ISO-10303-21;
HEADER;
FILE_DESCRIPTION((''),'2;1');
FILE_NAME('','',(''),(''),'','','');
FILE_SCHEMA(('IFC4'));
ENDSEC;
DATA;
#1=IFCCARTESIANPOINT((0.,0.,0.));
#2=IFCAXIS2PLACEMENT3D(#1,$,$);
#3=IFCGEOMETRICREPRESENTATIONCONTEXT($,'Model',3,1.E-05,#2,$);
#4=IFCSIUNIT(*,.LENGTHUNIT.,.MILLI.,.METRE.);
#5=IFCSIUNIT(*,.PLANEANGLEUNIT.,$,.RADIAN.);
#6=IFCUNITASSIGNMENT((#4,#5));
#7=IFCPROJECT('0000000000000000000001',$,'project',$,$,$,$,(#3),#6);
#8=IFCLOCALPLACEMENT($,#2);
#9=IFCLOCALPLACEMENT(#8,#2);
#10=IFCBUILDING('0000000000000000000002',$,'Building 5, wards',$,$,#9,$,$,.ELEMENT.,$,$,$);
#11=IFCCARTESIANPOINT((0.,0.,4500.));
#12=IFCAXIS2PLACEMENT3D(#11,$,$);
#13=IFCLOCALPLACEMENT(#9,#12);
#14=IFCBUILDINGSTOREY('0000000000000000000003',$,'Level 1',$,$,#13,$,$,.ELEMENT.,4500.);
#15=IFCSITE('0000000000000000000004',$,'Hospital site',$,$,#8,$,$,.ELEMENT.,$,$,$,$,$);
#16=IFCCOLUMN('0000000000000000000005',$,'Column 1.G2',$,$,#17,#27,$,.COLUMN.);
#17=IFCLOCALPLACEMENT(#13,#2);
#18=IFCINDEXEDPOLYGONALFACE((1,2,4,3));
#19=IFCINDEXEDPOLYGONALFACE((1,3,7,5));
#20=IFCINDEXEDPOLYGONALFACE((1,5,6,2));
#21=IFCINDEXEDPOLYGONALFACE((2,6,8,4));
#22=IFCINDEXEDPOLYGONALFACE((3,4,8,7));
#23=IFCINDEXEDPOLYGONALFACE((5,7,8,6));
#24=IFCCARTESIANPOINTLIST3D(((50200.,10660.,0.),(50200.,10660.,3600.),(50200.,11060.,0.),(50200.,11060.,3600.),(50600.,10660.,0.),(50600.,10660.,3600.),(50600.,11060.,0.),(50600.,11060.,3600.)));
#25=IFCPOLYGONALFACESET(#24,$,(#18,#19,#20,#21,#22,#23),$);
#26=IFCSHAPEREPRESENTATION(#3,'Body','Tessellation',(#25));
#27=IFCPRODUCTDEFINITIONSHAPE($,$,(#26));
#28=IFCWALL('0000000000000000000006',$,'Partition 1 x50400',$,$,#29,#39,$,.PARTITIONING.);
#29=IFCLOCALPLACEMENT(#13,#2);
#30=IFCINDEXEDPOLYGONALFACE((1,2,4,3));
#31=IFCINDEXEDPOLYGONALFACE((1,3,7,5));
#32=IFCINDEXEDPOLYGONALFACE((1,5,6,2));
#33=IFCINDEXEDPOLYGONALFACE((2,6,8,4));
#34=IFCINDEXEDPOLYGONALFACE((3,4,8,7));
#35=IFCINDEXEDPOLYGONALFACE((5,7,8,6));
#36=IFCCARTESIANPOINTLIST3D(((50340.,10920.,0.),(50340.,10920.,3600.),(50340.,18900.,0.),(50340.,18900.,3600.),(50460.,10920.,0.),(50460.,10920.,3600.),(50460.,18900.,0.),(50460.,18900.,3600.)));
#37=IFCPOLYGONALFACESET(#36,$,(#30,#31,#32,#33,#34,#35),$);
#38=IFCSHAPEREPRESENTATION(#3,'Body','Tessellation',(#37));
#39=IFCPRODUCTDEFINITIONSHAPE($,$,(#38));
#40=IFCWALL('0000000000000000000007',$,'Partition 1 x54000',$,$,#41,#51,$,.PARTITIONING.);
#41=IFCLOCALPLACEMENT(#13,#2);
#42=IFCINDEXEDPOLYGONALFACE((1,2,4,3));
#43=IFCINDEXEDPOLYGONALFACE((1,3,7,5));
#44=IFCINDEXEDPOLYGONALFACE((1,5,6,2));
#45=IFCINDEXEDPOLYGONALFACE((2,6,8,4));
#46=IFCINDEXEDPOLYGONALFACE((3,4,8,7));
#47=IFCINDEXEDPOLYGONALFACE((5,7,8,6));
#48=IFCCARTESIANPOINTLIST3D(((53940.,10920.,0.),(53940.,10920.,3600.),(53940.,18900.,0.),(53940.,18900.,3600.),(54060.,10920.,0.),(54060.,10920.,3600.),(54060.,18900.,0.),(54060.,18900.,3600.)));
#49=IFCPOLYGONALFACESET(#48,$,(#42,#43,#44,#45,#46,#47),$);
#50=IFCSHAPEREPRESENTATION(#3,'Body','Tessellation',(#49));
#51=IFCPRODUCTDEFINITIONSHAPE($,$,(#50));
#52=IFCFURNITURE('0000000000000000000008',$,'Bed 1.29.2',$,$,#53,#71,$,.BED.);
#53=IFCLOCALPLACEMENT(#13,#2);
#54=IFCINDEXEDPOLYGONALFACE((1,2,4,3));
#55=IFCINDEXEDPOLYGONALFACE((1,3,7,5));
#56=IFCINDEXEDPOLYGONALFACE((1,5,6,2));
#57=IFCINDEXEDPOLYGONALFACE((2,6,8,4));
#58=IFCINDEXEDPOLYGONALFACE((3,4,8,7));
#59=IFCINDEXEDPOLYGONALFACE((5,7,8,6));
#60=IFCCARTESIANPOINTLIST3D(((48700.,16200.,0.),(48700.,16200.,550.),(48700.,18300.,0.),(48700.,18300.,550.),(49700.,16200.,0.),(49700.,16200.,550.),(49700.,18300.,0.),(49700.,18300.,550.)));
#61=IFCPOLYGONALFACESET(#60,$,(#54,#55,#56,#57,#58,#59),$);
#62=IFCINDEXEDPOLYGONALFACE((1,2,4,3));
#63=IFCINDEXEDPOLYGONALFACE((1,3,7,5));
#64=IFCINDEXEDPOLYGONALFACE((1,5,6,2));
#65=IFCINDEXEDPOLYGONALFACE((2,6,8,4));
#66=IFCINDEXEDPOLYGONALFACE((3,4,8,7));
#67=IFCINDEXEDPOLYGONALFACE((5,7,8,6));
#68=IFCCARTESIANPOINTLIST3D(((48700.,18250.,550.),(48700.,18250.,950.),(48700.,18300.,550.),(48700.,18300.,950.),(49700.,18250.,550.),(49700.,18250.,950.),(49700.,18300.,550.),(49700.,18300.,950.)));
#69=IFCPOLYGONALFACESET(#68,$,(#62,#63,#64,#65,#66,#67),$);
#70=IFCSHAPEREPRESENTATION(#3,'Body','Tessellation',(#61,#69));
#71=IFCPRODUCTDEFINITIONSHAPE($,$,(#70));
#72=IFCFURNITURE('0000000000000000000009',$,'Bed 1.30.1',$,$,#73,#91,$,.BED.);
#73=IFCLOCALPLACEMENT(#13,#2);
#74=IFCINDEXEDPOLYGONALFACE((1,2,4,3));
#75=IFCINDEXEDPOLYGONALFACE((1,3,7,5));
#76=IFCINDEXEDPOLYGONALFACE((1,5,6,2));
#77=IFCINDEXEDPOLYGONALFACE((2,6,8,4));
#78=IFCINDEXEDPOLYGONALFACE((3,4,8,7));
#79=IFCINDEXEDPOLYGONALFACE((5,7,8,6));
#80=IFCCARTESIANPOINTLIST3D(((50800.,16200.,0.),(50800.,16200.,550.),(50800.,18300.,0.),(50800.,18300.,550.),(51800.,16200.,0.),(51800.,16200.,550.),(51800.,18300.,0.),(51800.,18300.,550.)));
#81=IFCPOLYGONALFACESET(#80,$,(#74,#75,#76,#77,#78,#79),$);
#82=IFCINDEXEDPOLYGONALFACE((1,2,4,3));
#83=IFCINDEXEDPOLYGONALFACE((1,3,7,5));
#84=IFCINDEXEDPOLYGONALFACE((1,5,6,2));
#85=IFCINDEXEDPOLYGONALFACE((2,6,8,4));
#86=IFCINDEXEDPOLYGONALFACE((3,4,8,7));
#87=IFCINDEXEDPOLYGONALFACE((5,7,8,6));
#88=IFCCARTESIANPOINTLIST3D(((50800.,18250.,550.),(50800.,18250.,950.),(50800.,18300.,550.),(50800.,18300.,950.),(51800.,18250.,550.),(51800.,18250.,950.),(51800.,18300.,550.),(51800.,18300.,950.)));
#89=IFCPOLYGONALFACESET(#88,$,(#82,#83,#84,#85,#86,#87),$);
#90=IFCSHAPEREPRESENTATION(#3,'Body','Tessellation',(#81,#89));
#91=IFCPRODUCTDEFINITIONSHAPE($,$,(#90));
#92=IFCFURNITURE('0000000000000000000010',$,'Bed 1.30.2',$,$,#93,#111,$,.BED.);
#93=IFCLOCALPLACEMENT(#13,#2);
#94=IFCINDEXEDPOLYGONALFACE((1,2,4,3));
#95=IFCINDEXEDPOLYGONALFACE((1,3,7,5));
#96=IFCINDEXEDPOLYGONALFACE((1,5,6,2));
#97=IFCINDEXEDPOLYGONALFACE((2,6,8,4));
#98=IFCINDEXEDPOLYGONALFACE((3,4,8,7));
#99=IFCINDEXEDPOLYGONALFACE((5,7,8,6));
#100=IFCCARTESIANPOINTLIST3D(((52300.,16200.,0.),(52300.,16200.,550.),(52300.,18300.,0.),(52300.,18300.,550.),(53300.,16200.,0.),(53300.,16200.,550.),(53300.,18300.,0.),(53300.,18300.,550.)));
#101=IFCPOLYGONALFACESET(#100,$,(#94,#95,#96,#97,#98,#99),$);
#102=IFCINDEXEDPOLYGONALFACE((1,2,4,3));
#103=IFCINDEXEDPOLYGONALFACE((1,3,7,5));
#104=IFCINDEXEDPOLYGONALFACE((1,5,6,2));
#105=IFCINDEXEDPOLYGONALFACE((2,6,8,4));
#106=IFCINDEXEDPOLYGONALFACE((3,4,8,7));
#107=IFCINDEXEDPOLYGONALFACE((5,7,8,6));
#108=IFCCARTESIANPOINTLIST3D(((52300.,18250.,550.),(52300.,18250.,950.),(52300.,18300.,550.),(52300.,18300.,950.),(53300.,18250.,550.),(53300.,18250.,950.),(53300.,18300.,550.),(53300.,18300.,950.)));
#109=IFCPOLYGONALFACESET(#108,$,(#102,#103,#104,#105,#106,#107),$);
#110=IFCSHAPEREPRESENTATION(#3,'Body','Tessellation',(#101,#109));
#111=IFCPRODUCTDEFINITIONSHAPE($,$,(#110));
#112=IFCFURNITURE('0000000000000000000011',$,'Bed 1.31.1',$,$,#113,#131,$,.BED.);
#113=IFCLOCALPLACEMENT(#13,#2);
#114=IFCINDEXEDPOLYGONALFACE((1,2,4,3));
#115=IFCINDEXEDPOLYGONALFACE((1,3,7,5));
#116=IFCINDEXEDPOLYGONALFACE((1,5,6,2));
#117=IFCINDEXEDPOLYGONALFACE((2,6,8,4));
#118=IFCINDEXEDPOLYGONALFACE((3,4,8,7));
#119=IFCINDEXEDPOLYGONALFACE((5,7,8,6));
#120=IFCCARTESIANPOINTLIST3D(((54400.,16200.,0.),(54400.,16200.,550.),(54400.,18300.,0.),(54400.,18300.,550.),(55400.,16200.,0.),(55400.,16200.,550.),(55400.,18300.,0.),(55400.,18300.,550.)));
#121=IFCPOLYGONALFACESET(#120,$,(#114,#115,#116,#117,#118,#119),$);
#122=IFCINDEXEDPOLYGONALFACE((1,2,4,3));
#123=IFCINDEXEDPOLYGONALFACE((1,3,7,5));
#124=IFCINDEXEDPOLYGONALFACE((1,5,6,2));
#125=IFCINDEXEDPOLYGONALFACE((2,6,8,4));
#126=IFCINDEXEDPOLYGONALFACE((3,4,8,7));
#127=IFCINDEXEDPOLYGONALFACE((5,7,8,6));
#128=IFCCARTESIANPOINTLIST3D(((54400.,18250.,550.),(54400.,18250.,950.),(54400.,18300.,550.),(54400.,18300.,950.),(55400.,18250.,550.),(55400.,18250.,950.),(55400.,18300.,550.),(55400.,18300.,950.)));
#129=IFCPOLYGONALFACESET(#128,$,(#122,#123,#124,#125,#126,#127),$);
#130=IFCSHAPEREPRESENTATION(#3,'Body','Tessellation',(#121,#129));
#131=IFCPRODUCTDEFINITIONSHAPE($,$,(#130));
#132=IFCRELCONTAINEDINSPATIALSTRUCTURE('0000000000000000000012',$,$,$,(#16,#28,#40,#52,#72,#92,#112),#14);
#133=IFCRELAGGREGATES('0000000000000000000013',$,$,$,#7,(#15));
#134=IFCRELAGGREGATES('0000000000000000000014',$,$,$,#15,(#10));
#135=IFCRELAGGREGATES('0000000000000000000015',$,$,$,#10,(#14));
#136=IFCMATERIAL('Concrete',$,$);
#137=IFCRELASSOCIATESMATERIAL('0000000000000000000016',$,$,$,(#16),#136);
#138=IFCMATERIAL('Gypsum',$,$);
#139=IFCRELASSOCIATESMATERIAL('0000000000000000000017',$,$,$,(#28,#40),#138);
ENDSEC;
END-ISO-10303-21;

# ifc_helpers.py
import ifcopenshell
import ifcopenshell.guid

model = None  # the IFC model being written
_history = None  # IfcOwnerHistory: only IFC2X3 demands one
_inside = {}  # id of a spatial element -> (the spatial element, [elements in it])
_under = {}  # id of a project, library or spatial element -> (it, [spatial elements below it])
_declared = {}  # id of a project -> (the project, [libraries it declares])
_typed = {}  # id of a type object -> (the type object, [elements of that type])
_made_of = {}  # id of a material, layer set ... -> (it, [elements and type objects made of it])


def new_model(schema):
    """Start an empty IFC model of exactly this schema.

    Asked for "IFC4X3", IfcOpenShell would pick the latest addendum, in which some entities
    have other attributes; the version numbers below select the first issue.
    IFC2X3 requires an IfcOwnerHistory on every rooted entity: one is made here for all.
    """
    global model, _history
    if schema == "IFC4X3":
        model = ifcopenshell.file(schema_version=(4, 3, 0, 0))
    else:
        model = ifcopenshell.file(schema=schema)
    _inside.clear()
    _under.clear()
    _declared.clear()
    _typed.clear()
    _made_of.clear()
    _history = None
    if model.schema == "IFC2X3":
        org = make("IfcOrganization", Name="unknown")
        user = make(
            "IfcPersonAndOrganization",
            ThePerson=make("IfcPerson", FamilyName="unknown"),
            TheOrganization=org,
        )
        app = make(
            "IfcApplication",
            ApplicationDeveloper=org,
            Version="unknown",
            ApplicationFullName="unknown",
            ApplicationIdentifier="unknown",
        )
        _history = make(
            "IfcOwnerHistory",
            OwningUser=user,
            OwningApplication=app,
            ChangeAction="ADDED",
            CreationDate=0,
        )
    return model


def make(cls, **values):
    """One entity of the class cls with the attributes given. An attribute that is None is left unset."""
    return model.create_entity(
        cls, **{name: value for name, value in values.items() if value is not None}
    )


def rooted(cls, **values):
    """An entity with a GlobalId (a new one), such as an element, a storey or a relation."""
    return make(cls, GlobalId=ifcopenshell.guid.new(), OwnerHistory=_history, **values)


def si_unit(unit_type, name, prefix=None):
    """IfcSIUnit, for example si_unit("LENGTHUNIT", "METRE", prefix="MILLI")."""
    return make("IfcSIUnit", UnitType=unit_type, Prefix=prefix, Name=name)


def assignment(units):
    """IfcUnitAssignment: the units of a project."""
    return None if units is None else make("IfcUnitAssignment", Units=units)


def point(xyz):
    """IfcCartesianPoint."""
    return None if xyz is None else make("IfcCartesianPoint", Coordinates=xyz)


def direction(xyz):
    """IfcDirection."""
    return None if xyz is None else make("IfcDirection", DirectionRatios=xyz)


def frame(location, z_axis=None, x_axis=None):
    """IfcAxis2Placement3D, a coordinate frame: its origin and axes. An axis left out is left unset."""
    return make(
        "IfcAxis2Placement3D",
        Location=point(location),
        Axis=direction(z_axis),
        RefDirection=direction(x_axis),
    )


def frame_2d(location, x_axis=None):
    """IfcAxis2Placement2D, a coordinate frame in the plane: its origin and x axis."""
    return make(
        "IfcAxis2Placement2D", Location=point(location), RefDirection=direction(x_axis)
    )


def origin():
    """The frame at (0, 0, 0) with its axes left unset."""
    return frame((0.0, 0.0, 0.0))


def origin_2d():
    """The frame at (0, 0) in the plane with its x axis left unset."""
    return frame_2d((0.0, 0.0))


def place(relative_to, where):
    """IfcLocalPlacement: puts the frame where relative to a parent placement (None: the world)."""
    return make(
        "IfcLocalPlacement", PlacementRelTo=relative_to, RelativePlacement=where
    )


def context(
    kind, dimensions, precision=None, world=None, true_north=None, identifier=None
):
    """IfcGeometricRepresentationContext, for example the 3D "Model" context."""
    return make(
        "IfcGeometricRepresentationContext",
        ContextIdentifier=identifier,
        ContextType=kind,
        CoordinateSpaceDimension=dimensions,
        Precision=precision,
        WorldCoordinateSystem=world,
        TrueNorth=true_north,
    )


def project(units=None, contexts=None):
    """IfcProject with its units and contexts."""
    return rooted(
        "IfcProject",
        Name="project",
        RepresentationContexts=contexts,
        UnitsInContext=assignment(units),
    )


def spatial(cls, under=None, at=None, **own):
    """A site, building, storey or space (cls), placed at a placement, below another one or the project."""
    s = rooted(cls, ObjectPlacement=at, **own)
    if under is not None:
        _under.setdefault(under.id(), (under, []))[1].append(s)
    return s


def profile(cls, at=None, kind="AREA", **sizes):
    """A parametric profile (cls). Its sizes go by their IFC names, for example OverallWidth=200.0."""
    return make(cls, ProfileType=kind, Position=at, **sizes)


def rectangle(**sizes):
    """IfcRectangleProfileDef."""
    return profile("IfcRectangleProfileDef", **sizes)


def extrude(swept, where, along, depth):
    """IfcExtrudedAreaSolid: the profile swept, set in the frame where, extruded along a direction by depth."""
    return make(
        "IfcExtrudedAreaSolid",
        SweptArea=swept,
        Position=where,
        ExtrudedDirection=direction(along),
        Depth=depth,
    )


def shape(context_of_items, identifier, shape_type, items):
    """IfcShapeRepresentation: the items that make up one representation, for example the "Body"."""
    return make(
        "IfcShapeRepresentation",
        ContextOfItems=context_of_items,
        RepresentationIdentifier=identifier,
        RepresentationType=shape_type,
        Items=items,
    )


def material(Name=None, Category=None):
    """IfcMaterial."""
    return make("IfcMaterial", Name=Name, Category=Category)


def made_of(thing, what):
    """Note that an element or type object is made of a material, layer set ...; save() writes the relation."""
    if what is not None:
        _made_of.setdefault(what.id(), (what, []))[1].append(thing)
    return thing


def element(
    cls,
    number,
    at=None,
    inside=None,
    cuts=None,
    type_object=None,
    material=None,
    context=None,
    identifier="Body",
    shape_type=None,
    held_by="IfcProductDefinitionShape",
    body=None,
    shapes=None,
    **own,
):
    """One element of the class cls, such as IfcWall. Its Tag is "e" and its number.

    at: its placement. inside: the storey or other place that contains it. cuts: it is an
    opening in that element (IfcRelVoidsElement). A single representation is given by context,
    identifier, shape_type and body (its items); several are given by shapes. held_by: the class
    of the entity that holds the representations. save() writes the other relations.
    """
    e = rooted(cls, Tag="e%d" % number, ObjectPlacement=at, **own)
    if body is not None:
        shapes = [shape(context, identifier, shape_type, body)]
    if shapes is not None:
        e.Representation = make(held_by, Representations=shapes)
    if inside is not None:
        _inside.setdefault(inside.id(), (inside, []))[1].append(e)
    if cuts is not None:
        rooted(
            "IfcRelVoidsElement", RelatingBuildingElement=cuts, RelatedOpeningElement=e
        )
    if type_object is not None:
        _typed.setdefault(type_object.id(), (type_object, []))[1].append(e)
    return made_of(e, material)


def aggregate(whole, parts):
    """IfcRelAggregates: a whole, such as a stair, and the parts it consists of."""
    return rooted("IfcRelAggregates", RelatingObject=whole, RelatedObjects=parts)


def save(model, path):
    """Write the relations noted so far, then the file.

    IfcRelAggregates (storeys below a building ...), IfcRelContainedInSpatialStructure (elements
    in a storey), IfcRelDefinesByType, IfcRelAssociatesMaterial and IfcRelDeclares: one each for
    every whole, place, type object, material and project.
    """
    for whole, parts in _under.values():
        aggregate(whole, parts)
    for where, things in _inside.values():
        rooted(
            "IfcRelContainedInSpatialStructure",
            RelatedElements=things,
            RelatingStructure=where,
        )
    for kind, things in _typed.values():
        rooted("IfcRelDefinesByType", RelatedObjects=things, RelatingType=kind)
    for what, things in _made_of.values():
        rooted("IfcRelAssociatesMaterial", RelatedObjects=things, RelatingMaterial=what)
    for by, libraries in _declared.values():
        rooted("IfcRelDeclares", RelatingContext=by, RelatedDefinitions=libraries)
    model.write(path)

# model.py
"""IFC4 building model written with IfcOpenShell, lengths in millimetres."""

from ifc_helpers import new_model, si_unit, frame, frame_2d, origin, origin_2d, place, context, project, spatial, rectangle, extrude, material, element, save


model = new_model("IFC4")

# Units and contexts
model_context = context("Model", 3, precision=1e-05, world=origin())
ifc_project = project(units=[si_unit("LENGTHUNIT", "METRE", prefix="MILLI"), si_unit("PLANEANGLEUNIT", "RADIAN")], contexts=[model_context])

# Site, building, storey
site_placement = place(None, origin())
site = spatial("IfcSite", under=ifc_project, at=site_placement, Name="Hospital site", CompositionType="ELEMENT")
building_placement = place(site_placement, origin())
building = spatial("IfcBuilding", under=site, at=building_placement, Name="Building 5, wards", CompositionType="ELEMENT")
storey_placement = place(building_placement, frame((0.0, 0.0, 4500.0)))
storey = spatial("IfcBuildingStorey", under=building, at=storey_placement, Name="Level 1", CompositionType="ELEMENT", Elevation=4500.0)

# Column
ifc_material_1 = material(Name="Concrete")
column_placement = place(storey_placement, frame((50400.0, 10860.0, 0.0)))
element("IfcColumn", 1, at=column_placement, inside=storey, material=ifc_material_1, Name="Column 1.G2", PredefinedType="COLUMN", context=model_context, shape_type="SweptSolid", body=[
    extrude(rectangle(XDim=400.0, YDim=400.0, at=origin_2d()), origin(), (0.0, 0.0, 1.0), 3600.0),
])

# Walls
ifc_material_2 = material(Name="Gypsum")
for number, where, x_axis, name in (
    (2, (50460.0, 10920.0, 0.0), (0.0, 1.0, 0.0), "Partition 1 x50400"),
    (3, (54060.0, 10920.0, 0.0), (0.0, 1.0, 0.0), "Partition 1 x54000"),
):
    element("IfcWall", number, at=place(storey_placement, frame(where, x_axis=x_axis)), inside=storey, material=ifc_material_2, Name=name, PredefinedType="PARTITIONING", context=model_context, shape_type="SweptSolid", body=[
        extrude(rectangle(XDim=7980.0, YDim=120.0, at=frame_2d((3990.0, 60.0))), origin(), (0.0, 0.0, 1.0), 3600.0),
    ])

# Furniture
for number, where, name in (
    (4, (48700.0, 16200.0, 0.0), "Bed 1.29.2"),
    (5, (50800.0, 16200.0, 0.0), "Bed 1.30.1"),
    (6, (52300.0, 16200.0, 0.0), "Bed 1.30.2"),
    (7, (54400.0, 16200.0, 0.0), "Bed 1.31.1"),
):
    element("IfcFurniture", number, at=place(storey_placement, frame(where)), inside=storey, Name=name, PredefinedType="BED", context=model_context, shape_type="SweptSolid", body=[
        extrude(rectangle(XDim=1000.0, YDim=2100.0, at=frame_2d((500.0, 1050.0))), origin(), (0.0, 0.0, 1.0), 550.0),
        extrude(rectangle(XDim=1000.0, YDim=50.0, at=frame_2d((500.0, 2075.0))), frame((0.0, 0.0, 550.0)), (0.0, 0.0, 1.0), 400.0),
    ])

save(model, "model.ifc")
